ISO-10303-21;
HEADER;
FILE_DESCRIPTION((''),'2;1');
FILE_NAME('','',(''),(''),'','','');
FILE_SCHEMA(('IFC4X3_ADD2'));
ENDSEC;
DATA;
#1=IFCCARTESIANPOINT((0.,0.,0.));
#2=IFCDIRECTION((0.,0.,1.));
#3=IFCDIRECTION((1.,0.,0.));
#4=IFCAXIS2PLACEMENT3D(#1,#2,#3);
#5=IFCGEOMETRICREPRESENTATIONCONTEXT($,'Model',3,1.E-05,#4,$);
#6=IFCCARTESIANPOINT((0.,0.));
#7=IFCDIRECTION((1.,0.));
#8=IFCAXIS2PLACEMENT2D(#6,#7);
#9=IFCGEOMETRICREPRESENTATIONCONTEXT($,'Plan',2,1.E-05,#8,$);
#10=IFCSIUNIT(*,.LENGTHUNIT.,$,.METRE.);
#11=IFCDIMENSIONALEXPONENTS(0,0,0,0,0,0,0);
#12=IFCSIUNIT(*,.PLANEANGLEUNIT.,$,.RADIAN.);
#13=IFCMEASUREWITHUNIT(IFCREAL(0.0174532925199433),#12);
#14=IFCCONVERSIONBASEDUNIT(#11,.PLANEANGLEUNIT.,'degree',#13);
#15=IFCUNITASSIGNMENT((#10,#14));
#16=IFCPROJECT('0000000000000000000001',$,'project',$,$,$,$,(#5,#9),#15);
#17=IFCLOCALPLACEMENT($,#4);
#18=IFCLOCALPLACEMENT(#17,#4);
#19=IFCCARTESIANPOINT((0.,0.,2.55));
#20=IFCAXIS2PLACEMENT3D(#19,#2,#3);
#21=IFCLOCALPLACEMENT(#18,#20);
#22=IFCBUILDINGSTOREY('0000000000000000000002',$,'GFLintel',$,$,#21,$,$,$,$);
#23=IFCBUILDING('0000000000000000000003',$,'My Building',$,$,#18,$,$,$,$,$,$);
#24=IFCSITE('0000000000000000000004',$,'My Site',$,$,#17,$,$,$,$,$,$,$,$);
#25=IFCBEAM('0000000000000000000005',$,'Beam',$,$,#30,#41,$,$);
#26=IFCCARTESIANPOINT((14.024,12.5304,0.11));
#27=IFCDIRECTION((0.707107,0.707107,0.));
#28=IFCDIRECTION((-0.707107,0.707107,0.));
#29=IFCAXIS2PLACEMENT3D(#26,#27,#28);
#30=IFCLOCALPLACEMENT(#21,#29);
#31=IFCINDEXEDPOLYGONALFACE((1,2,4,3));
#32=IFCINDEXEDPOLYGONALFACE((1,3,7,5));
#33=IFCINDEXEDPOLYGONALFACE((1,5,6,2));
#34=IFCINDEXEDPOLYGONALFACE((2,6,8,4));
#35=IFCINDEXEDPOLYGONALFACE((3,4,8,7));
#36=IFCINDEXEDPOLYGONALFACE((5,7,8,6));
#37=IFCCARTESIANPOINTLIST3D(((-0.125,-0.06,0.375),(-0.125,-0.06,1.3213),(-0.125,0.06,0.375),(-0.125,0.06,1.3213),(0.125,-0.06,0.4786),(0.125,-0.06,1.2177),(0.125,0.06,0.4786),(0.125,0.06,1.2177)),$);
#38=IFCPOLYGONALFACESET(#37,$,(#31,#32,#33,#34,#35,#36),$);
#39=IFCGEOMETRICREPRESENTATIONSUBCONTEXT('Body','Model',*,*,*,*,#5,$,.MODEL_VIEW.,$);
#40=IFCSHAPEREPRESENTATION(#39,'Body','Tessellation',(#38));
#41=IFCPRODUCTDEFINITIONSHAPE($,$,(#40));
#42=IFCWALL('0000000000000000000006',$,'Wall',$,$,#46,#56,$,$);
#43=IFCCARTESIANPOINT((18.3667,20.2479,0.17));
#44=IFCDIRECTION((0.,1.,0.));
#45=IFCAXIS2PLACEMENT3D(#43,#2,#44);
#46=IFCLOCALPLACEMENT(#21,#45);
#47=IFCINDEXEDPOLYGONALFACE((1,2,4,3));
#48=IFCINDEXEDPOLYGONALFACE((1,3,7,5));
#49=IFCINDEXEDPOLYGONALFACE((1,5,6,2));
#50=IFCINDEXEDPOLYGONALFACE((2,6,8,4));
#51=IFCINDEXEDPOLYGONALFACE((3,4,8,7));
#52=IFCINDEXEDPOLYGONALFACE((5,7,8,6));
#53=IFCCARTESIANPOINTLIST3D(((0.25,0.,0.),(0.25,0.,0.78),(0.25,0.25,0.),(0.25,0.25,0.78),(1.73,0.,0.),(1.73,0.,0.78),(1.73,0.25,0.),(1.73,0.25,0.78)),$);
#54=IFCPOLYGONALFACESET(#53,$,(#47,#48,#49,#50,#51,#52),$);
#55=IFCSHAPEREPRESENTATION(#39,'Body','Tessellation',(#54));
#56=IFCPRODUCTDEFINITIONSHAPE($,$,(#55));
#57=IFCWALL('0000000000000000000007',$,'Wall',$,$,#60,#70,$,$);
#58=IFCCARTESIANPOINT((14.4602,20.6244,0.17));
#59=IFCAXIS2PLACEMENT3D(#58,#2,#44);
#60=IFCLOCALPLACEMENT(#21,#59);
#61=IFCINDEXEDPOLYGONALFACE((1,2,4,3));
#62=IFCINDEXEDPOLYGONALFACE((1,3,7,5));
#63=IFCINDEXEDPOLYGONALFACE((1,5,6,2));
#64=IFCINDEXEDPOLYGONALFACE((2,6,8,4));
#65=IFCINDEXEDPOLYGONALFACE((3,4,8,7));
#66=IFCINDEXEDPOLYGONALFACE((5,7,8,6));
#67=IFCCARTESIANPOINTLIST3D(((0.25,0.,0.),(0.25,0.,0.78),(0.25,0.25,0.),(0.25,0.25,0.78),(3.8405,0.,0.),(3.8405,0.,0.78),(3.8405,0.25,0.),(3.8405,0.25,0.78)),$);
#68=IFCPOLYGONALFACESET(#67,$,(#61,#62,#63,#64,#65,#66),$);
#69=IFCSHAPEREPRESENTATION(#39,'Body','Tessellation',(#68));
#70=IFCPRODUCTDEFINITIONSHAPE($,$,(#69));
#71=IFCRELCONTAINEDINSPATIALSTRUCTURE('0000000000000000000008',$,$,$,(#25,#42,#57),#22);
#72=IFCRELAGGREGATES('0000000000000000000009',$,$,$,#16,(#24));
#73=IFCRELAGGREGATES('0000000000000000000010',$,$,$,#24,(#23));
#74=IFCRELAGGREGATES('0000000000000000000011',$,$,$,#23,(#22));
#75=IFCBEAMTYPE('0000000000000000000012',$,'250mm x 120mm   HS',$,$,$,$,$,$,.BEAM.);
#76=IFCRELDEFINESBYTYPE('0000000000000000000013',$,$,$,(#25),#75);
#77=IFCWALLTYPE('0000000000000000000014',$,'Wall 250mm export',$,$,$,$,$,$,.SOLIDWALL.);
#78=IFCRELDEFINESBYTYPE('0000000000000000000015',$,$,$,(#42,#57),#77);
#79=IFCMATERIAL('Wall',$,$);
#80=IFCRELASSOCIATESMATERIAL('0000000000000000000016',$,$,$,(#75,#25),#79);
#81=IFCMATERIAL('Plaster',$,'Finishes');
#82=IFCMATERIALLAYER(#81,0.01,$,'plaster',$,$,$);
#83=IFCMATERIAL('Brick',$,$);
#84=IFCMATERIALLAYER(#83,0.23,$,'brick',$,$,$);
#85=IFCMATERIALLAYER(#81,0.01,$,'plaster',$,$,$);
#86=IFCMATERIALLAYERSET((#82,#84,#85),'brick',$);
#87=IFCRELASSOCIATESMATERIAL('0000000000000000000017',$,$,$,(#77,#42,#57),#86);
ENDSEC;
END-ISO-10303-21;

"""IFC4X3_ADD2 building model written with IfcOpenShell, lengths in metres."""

from ifc_helpers import new_model, entity, si_unit, converted_unit, frame, origin_with_axes, origin_2d_with_axis, place, context, subcontext, project, spatial, line, indexed_curve, rectangle, outline, extrude, clip, halfspace, material, layer, layer_set, layer_usage, material_profile, profile_set, profile_usage, type_object, element, save


model = new_model("IFC4X3_ADD2")

# Units and contexts
model_context = context("Model", 3, precision=1e-05, world=origin_with_axes())
plan_context = context("Plan", 2, precision=1e-05, world=origin_2d_with_axis())
body_context = subcontext(model_context, "Body", "Model", "MODEL_VIEW")
ifc_project = project(units=[si_unit("LENGTHUNIT", "METRE"), converted_unit("PLANEANGLEUNIT", "degree", entity("IfcReal", 0.0174532925199433), si_unit("PLANEANGLEUNIT", "RADIAN"), dimensions=[0, 0, 0, 0, 0, 0, 0])], contexts=[model_context, plan_context])

# Site, building, storey
site_placement = place(None, origin_with_axes())
site = spatial("IfcSite", under=ifc_project, at=site_placement, Name="My Site")
building_placement = place(site_placement, origin_with_axes())
building = spatial("IfcBuilding", under=site, at=building_placement, Name="My Building")
storey_placement = place(building_placement, frame((0.0, 0.0, 2.55), z_axis=(0.0, 0.0, 1.0), x_axis=(1.0, 0.0, 0.0)))
storey = spatial("IfcBuildingStorey", under=building, at=storey_placement, Name="GFLintel")

# Beam
ifc_material_1 = material(Name="Wall")
ifc_material_profile_1 = material_profile(ifc_material_1, rectangle(XDim=0.25, YDim=0.12))
ifc_profile_set_1 = profile_set([ifc_material_profile_1], Name="concrete")
beam_type_1 = type_object("IfcBeamType", Name="250mm x 120mm   HS", PredefinedType="BEAM", material=ifc_profile_set_1)
ifc_profile_usage_1 = profile_usage(ifc_profile_set_1, cardinal=5)
beam_1_placement = place(storey_placement, frame((14.024, 12.5304, 0.11), z_axis=(0.707107, 0.707107, 0.0), x_axis=(-0.707107, 0.707107, 0.0)))
element("IfcBeam", 1, at=beam_1_placement, inside=storey, type_object=beam_type_1, material=ifc_profile_usage_1, Name="Beam", context=body_context, shape_type="Clipping", body=[
    clip(clip(extrude(rectangle(XDim=0.25, YDim=0.12), origin_with_axes(), (0.0, 0.0, 1.0), 1.6963), halfspace(frame((-0.125, -2.66, 1.3213), z_axis=(0.382685, 0.0, 0.923879), x_axis=(0.0, -1.0, 0.0)), False)), halfspace(frame((-0.125, -2.66, 0.375), z_axis=(0.382682, 0.0, -0.92388), x_axis=(0.0, -1.0, 0.0)), False)),
])

# Walls
ifc_material_2 = material(Name="Plaster", Category="Finishes")
ifc_layer_1 = layer(ifc_material_2, 0.01, Name="plaster")
ifc_material_3 = material(Name="Brick")
ifc_layer_2 = layer(ifc_material_3, 0.23, Name="brick")
ifc_layer_3 = layer(ifc_material_2, 0.01, Name="plaster")
ifc_layer_set_1 = layer_set([ifc_layer_1, ifc_layer_2, ifc_layer_3], Name="brick")
ifc_layer_usage_1 = layer_usage(ifc_layer_set_1, "AXIS2", "POSITIVE", 0.0)
wall_type_1 = type_object("IfcWallType", Name="Wall 250mm export", PredefinedType="SOLIDWALL", material=ifc_layer_set_1)
wall_1_placement = place(storey_placement, frame((18.3667, 20.2479, 0.17), z_axis=(0.0, 0.0, 1.0), x_axis=(0.0, 1.0, 0.0)))
element("IfcWall", 2, at=wall_1_placement, inside=storey, type_object=wall_type_1, material=ifc_layer_usage_1, Name="Wall", context=body_context, shape_type="SweptSolid", body=[
    extrude(outline(indexed_curve([(0.25, 0.0), (0.25, 0.25), (1.73, 0.25), (1.73, 0.0)], segments=[line(1, 2, 3, 4, 1)])), origin_with_axes(), (0.0, 0.0, 1.0), 0.78),
])
ifc_layer_usage_2 = layer_usage(ifc_layer_set_1, "AXIS2", "POSITIVE", 0.0)
wall_2_placement = place(storey_placement, frame((14.4602, 20.6244, 0.17), z_axis=(0.0, 0.0, 1.0), x_axis=(0.0, 1.0, 0.0)))
element("IfcWall", 3, at=wall_2_placement, inside=storey, type_object=wall_type_1, material=ifc_layer_usage_2, Name="Wall", context=body_context, shape_type="SweptSolid", body=[
    extrude(outline(indexed_curve([(0.25, 0.0), (0.25, 0.25), (3.8405, 0.25), (3.8405, 0.0)], segments=[line(1, 2, 3, 4, 1)])), origin_with_axes(), (0.0, 0.0, 1.0), 0.78),
])

save(model, "model.ifc")
